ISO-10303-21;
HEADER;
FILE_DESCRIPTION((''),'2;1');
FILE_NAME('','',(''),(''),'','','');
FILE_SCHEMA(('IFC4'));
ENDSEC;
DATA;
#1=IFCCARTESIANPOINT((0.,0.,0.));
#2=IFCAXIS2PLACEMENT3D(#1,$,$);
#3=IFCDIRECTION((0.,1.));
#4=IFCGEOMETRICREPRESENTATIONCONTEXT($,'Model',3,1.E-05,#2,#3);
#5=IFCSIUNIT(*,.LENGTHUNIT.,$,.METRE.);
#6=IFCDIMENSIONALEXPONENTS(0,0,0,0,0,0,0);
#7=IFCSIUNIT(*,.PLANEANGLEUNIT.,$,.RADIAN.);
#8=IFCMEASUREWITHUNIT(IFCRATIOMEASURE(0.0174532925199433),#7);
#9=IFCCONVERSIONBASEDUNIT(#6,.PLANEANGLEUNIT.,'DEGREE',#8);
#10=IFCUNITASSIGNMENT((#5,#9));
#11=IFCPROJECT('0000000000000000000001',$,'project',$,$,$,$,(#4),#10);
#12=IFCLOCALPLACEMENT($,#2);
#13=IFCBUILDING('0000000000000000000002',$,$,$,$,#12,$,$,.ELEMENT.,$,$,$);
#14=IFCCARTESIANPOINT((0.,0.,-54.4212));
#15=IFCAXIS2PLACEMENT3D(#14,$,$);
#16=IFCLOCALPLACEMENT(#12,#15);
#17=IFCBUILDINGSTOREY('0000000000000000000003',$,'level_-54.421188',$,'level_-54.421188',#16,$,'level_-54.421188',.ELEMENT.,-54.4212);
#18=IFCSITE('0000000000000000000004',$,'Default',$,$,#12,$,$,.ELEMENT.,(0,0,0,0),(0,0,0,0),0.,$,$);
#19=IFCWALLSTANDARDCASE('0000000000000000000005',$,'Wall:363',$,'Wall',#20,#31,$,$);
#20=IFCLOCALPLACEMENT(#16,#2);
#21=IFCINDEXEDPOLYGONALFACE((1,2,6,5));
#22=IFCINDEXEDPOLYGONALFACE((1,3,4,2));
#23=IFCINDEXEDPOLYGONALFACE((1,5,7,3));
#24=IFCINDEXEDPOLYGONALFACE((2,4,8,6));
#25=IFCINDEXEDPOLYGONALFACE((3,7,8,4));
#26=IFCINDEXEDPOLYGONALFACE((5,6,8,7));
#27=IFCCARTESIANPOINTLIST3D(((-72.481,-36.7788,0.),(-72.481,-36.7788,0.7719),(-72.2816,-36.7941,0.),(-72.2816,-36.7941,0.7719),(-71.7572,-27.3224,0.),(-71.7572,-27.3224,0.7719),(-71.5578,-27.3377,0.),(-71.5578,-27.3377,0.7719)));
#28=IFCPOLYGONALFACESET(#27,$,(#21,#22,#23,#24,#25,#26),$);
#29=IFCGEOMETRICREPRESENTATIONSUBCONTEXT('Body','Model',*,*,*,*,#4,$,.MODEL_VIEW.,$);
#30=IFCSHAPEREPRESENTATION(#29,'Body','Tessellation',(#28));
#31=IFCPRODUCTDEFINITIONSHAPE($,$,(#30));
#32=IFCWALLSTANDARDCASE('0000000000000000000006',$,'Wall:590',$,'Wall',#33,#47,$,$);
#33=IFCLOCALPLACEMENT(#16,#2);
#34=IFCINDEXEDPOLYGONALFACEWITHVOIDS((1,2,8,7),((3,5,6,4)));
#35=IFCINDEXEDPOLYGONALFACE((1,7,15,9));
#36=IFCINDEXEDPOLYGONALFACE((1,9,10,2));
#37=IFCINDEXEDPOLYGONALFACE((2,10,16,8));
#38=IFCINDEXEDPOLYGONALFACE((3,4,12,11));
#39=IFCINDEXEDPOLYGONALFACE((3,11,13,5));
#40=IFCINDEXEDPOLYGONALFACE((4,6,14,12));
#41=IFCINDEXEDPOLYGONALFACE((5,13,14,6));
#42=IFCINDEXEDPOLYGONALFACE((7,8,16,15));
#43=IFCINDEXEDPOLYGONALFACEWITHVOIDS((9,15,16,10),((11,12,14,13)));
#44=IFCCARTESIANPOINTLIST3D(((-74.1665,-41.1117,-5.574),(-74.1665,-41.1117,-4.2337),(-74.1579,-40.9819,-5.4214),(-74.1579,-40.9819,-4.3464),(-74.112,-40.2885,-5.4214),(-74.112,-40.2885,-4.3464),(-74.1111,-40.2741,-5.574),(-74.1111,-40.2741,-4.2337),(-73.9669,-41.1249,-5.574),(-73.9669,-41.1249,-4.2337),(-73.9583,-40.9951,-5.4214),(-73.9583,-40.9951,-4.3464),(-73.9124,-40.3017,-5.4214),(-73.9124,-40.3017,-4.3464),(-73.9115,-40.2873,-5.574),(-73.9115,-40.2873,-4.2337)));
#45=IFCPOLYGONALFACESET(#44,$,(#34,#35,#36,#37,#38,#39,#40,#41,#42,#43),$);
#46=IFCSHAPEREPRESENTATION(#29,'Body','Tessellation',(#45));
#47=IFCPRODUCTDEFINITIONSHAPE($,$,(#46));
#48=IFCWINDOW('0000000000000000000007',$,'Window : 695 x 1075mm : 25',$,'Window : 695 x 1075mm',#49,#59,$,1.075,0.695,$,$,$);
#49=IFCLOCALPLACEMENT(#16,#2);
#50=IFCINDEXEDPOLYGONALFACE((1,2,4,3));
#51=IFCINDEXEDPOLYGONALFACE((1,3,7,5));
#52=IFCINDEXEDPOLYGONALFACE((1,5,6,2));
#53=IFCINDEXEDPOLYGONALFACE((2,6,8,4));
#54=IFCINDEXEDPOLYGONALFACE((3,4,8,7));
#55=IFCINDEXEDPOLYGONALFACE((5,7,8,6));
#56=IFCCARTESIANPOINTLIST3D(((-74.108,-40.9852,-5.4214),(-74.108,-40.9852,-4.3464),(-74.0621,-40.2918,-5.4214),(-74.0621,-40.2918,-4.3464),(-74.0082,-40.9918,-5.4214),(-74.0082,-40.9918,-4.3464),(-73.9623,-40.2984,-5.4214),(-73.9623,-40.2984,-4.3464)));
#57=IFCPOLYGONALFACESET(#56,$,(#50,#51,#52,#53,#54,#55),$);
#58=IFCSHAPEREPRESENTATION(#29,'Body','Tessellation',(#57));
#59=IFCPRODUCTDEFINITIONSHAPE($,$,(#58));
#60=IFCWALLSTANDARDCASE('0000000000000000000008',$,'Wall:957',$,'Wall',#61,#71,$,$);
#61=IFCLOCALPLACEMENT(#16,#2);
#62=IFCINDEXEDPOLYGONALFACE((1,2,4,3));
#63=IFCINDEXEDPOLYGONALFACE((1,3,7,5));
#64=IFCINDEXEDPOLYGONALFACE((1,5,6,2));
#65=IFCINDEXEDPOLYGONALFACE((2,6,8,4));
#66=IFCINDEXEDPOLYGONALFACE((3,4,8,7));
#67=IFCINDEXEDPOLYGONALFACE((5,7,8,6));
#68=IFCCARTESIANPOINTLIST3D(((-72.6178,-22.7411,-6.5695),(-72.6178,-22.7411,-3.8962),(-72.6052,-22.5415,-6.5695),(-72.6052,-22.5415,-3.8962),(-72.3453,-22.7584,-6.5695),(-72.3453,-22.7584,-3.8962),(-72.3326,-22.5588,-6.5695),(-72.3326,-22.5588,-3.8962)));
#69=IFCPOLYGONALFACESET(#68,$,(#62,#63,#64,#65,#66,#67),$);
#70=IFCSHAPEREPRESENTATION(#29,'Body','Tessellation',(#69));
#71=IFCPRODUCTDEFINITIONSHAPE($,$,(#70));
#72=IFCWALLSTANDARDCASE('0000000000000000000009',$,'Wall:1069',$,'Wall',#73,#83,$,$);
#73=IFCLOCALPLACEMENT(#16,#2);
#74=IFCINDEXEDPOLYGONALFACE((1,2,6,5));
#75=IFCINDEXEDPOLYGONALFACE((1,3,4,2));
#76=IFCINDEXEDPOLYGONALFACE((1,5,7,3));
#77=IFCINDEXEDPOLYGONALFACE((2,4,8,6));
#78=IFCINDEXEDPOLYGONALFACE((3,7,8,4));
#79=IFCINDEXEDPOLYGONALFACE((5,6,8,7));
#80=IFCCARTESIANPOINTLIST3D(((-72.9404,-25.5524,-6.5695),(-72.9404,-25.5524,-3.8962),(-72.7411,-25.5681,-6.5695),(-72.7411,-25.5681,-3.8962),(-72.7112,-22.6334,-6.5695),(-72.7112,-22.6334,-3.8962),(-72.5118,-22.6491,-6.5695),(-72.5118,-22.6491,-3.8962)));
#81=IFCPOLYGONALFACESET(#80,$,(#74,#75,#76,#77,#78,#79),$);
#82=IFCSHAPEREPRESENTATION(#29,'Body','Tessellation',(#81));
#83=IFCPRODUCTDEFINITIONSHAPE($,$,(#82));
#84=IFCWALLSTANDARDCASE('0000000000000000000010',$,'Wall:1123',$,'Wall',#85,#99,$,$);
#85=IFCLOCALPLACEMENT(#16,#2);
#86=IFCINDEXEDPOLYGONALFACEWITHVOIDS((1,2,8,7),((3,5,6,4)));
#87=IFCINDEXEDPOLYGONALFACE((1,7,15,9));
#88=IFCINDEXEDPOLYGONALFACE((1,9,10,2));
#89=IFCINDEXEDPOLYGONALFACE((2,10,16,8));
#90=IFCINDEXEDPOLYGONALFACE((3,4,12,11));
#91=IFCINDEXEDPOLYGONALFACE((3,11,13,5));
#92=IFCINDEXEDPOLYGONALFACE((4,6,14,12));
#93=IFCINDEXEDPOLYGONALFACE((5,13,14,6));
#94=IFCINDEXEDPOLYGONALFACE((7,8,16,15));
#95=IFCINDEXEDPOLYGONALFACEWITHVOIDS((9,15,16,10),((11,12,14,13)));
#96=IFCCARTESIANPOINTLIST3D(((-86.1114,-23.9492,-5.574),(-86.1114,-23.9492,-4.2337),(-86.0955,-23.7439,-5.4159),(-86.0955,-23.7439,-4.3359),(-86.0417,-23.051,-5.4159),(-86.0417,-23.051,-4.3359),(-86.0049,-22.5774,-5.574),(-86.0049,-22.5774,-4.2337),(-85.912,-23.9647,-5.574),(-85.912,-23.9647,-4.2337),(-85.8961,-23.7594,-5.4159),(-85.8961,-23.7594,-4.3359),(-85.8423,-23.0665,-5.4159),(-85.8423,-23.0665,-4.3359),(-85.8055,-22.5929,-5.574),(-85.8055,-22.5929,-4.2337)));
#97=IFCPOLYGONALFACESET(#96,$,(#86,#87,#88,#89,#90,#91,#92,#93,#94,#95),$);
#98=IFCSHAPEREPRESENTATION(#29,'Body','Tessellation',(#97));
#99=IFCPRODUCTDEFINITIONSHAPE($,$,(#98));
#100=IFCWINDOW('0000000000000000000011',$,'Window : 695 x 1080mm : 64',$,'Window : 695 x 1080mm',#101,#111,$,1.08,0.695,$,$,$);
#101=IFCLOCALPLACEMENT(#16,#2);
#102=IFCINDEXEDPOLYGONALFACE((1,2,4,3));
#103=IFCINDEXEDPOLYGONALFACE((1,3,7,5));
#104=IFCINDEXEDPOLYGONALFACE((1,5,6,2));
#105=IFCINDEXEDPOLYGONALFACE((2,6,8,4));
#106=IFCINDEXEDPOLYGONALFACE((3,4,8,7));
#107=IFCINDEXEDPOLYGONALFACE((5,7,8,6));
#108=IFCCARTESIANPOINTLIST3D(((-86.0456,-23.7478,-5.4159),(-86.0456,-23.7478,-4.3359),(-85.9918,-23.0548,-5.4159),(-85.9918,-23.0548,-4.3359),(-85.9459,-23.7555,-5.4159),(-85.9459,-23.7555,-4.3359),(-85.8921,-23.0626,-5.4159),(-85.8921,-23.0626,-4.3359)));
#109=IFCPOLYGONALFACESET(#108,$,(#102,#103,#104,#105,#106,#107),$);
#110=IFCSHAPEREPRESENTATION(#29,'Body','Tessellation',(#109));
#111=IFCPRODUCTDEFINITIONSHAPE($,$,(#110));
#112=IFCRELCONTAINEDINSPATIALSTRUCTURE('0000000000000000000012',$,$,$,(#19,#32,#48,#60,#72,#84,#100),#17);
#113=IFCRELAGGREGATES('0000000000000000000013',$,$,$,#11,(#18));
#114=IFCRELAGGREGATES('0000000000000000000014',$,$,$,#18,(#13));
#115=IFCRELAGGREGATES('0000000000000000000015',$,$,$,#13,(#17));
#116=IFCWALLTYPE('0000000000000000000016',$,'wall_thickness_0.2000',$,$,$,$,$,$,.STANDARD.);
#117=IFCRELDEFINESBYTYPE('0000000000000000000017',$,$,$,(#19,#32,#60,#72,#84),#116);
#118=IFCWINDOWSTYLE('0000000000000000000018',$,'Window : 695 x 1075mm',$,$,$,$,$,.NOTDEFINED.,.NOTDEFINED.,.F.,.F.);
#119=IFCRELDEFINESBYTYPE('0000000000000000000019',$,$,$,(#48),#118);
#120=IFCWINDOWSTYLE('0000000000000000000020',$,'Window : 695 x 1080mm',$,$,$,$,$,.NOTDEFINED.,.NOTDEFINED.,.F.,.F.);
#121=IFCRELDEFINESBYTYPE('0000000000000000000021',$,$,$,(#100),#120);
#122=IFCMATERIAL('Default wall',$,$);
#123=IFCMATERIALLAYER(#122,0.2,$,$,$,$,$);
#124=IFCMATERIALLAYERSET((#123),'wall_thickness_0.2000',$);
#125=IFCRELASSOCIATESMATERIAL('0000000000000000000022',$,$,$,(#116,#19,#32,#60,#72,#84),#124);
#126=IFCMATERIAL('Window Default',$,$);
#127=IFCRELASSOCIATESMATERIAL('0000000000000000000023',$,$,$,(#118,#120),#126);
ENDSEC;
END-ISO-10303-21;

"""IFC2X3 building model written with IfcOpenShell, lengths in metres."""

from ifc_helpers import new_model, entity, si_unit, converted_unit, direction, frame, frame_2d, origin, origin_2d_with_axis, place, context, subcontext, project, spatial, polyline, rectangle, outline, extrude, source, transform, mapped, material, layer, layer_set, layer_usage, type_object, type_shapes, element, fill, save


model = new_model("IFC2X3")

# Units and contexts
model_context = context("Model", 3, precision=1e-05, world=origin(), true_north=direction((0.0, 1.0)))
body_context = subcontext(model_context, "Body", "Model", "MODEL_VIEW")
ifc_project = project(units=[si_unit("LENGTHUNIT", "METRE"), converted_unit("PLANEANGLEUNIT", "DEGREE", entity("IfcRatioMeasure", 0.0174532925199433), si_unit("PLANEANGLEUNIT", "RADIAN"), dimensions=[0, 0, 0, 0, 0, 0, 0])], contexts=[model_context])

# Site, building, storey
placement_1 = place(None, origin())
site = spatial("IfcSite", under=ifc_project, at=placement_1, Name="Default", CompositionType="ELEMENT", RefLatitude=(0, 0, 0, 0), RefLongitude=(0, 0, 0, 0), RefElevation=0.0)
building = spatial("IfcBuilding", under=site, at=placement_1, CompositionType="ELEMENT")
storey_placement = place(placement_1, frame((0.0, 0.0, -54.4212)))
storey = spatial("IfcBuildingStorey", under=building, at=storey_placement, Name="level_-54.421188", ObjectType="level_-54.421188", LongName="level_-54.421188", CompositionType="ELEMENT", Elevation=-54.4212)

# Wall
ifc_material_1 = material(Name="Default wall")
ifc_layer = layer(ifc_material_1, 0.2)
ifc_layer_set = layer_set([ifc_layer], Name="wall_thickness_0.2000")
ifc_layer_usage = layer_usage(ifc_layer_set, "AXIS2", "POSITIVE", -0.1)
wall_type = type_object("IfcWallType", Name="wall_thickness_0.2000", PredefinedType="STANDARD", material=ifc_layer_set)
wall_1_placement = place(storey_placement, frame((-72.3813, -36.7864, 0.0), z_axis=(0.0, 0.0, 1.0), x_axis=(0.076319, 0.997083, 0.0)))
element("IfcWallStandardCase", 1, at=wall_1_placement, inside=storey, type_object=wall_type, material=ifc_layer_usage, Name="Wall:363", ObjectType="Wall", context=body_context, shape_type="SweptSolid", body=[
    extrude(outline(polyline([(9.4841, -0.1), (9.4841, 0.1), (0.0, 0.1), (0.0, -0.1), (9.4841, -0.1)])), origin(), (0.0, 0.0, 1.0), 0.7719),
])

# Wall, opening, window
placement_2 = place(placement_1, frame((0.0, 0.0, -59.9952)))
wall_2_placement = place(placement_2, frame((-74.0113, -40.2807, 0.0), z_axis=(0.0, 0.0, 1.0), x_axis=(-0.066003, -0.997819, 0.0)))
wall_2 = element("IfcWallStandardCase", 2, at=wall_2_placement, inside=storey, type_object=wall_type, material=ifc_layer_usage, Name="Wall:590", ObjectType="Wall", context=body_context, shape_type="SweptSolid", body=[
    extrude(outline(polyline([(0.8394, -0.1), (0.8394, 0.1), (0.0, 0.1), (0.0, -0.1), (0.8394, -0.1)])), origin(), (0.0, 0.0, 1.0), 1.3402),
])
opening_1_placement = place(wall_2_placement, frame((0.0144, -0.1, 0.1526)))
opening_1 = element("IfcOpeningElement", 3, at=opening_1_placement, cuts=wall_2, ObjectType="Opening", context=body_context, shape_type="SweptSolid", body=[
    extrude(rectangle(XDim=0.695, YDim=1.075, at=frame_2d((0.5375, 0.3475), x_axis=(0.0, 1.0))), frame((0.0, 0.0, 0.0), z_axis=(0.0, 1.0, 0.0), x_axis=(0.0, 0.0, 1.0)), (0.0, 0.0, 1.0), 0.2),
])
ifc_material_2 = material(Name="Window Default")
window_style_1 = type_object("IfcWindowStyle", Name="Window : 695 x 1075mm", ConstructionType="NOTDEFINED", OperationType="NOTDEFINED", ParameterTakesPrecedence=False, Sizeable=False, material=ifc_material_2)
shared_shape_1 = source(origin(), body_context, "Body", "SweptSolid", [
    extrude(rectangle(XDim=0.1, YDim=0.695, at=origin_2d_with_axis()), frame((0.3475, 0.1, 0.0), z_axis=(0.0, 0.0, 1.0), x_axis=(0.0, 1.0, 0.0)), (0.0, 0.0, 1.0), 1.075),
])
type_shapes(window_style_1, [shared_shape_1])
window_1_placement = place(opening_1_placement, origin())
window_1 = element("IfcWindow", 4, at=window_1_placement, inside=storey, type_object=window_style_1, Name="Window : 695 x 1075mm : 25", ObjectType="Window : 695 x 1075mm", OverallHeight=1.075, OverallWidth=0.695, context=body_context, shape_type="MappedRepresentation", body=[
    mapped(shared_shape_1, transform((0.0, 0.0, 0.0), scale=1.0)),
])
fill(opening_1, window_1)

# Walls
placement_3 = place(placement_1, frame((0.0, 0.0, -60.9907)))
wall_3_placement = place(placement_3, frame((-72.339, -22.6586, 0.0), z_axis=(0.0, 0.0, 1.0), x_axis=(-0.997993, 0.063328, 0.0)))
element("IfcWallStandardCase", 5, at=wall_3_placement, inside=storey, type_object=wall_type, material=ifc_layer_usage, Name="Wall:957", ObjectType="Wall", context=body_context, shape_type="SweptSolid", body=[
    extrude(outline(polyline([(0.2731, -0.1), (0.2731, 0.1), (0.0, 0.1), (0.0, -0.1), (0.2731, -0.1)])), origin(), (0.0, 0.0, 1.0), 2.6733),
])
placement_4 = place(placement_1, frame((0.0, 0.0, -60.9907)))
wall_4_placement = place(placement_4, frame((-72.6115, -22.6413, 0.0), z_axis=(0.0, 0.0, 1.0), x_axis=(-0.078298, -0.99693, 0.0)))
element("IfcWallStandardCase", 6, at=wall_4_placement, inside=storey, type_object=wall_type, material=ifc_layer_usage, Name="Wall:1069", ObjectType="Wall", context=body_context, shape_type="SweptSolid", body=[
    extrude(outline(polyline([(2.928, -0.1), (2.928, 0.1), (0.0, 0.1), (0.0, -0.1), (2.928, -0.1)])), origin(), (0.0, 0.0, 1.0), 2.6733),
])

# Wall, opening, window
placement_5 = place(placement_1, frame((0.0, 0.0, -59.9952)))
wall_5_placement = place(placement_5, frame((-85.9052, -22.5851, 0.0), z_axis=(0.0, 0.0, 1.0), x_axis=(-0.07738, -0.997002, 0.0)))
wall_5 = element("IfcWallStandardCase", 7, at=wall_5_placement, inside=storey, type_object=wall_type, material=ifc_layer_usage, Name="Wall:1123", ObjectType="Wall", context=body_context, shape_type="SweptSolid", body=[
    extrude(outline(polyline([(1.3759, -0.1), (1.3759, 0.1), (0.0, 0.1), (0.0, -0.1), (1.3759, -0.1)])), origin(), (0.0, 0.0, 1.0), 1.3402),
])
opening_2_placement = place(wall_5_placement, frame((0.475, -0.1, 0.1581)))
opening_2 = element("IfcOpeningElement", 8, at=opening_2_placement, cuts=wall_5, ObjectType="Opening", context=body_context, shape_type="SweptSolid", body=[
    extrude(rectangle(XDim=0.695, YDim=1.08, at=frame_2d((0.54, 0.3475), x_axis=(0.0, 1.0))), frame((0.0, 0.0, 0.0), z_axis=(0.0, 1.0, 0.0), x_axis=(0.0, 0.0, 1.0)), (0.0, 0.0, 1.0), 0.2),
])
window_style_2 = type_object("IfcWindowStyle", Name="Window : 695 x 1080mm", ConstructionType="NOTDEFINED", OperationType="NOTDEFINED", ParameterTakesPrecedence=False, Sizeable=False, material=ifc_material_2)
shared_shape_2 = source(origin(), body_context, "Body", "SweptSolid", [
    extrude(rectangle(XDim=0.1, YDim=0.695, at=origin_2d_with_axis()), frame((0.3475, 0.1, 0.0), z_axis=(0.0, 0.0, 1.0), x_axis=(0.0, 1.0, 0.0)), (0.0, 0.0, 1.0), 1.08),
])
type_shapes(window_style_2, [shared_shape_2])
window_2_placement = place(opening_2_placement, origin())
window_2 = element("IfcWindow", 9, at=window_2_placement, inside=storey, type_object=window_style_2, Name="Window : 695 x 1080mm : 64", ObjectType="Window : 695 x 1080mm", OverallHeight=1.08, OverallWidth=0.695, context=body_context, shape_type="MappedRepresentation", body=[
    mapped(shared_shape_2, transform((0.0, 0.0, 0.0), scale=1.0)),
])
fill(opening_2, window_2)

save(model, "model.ifc")
